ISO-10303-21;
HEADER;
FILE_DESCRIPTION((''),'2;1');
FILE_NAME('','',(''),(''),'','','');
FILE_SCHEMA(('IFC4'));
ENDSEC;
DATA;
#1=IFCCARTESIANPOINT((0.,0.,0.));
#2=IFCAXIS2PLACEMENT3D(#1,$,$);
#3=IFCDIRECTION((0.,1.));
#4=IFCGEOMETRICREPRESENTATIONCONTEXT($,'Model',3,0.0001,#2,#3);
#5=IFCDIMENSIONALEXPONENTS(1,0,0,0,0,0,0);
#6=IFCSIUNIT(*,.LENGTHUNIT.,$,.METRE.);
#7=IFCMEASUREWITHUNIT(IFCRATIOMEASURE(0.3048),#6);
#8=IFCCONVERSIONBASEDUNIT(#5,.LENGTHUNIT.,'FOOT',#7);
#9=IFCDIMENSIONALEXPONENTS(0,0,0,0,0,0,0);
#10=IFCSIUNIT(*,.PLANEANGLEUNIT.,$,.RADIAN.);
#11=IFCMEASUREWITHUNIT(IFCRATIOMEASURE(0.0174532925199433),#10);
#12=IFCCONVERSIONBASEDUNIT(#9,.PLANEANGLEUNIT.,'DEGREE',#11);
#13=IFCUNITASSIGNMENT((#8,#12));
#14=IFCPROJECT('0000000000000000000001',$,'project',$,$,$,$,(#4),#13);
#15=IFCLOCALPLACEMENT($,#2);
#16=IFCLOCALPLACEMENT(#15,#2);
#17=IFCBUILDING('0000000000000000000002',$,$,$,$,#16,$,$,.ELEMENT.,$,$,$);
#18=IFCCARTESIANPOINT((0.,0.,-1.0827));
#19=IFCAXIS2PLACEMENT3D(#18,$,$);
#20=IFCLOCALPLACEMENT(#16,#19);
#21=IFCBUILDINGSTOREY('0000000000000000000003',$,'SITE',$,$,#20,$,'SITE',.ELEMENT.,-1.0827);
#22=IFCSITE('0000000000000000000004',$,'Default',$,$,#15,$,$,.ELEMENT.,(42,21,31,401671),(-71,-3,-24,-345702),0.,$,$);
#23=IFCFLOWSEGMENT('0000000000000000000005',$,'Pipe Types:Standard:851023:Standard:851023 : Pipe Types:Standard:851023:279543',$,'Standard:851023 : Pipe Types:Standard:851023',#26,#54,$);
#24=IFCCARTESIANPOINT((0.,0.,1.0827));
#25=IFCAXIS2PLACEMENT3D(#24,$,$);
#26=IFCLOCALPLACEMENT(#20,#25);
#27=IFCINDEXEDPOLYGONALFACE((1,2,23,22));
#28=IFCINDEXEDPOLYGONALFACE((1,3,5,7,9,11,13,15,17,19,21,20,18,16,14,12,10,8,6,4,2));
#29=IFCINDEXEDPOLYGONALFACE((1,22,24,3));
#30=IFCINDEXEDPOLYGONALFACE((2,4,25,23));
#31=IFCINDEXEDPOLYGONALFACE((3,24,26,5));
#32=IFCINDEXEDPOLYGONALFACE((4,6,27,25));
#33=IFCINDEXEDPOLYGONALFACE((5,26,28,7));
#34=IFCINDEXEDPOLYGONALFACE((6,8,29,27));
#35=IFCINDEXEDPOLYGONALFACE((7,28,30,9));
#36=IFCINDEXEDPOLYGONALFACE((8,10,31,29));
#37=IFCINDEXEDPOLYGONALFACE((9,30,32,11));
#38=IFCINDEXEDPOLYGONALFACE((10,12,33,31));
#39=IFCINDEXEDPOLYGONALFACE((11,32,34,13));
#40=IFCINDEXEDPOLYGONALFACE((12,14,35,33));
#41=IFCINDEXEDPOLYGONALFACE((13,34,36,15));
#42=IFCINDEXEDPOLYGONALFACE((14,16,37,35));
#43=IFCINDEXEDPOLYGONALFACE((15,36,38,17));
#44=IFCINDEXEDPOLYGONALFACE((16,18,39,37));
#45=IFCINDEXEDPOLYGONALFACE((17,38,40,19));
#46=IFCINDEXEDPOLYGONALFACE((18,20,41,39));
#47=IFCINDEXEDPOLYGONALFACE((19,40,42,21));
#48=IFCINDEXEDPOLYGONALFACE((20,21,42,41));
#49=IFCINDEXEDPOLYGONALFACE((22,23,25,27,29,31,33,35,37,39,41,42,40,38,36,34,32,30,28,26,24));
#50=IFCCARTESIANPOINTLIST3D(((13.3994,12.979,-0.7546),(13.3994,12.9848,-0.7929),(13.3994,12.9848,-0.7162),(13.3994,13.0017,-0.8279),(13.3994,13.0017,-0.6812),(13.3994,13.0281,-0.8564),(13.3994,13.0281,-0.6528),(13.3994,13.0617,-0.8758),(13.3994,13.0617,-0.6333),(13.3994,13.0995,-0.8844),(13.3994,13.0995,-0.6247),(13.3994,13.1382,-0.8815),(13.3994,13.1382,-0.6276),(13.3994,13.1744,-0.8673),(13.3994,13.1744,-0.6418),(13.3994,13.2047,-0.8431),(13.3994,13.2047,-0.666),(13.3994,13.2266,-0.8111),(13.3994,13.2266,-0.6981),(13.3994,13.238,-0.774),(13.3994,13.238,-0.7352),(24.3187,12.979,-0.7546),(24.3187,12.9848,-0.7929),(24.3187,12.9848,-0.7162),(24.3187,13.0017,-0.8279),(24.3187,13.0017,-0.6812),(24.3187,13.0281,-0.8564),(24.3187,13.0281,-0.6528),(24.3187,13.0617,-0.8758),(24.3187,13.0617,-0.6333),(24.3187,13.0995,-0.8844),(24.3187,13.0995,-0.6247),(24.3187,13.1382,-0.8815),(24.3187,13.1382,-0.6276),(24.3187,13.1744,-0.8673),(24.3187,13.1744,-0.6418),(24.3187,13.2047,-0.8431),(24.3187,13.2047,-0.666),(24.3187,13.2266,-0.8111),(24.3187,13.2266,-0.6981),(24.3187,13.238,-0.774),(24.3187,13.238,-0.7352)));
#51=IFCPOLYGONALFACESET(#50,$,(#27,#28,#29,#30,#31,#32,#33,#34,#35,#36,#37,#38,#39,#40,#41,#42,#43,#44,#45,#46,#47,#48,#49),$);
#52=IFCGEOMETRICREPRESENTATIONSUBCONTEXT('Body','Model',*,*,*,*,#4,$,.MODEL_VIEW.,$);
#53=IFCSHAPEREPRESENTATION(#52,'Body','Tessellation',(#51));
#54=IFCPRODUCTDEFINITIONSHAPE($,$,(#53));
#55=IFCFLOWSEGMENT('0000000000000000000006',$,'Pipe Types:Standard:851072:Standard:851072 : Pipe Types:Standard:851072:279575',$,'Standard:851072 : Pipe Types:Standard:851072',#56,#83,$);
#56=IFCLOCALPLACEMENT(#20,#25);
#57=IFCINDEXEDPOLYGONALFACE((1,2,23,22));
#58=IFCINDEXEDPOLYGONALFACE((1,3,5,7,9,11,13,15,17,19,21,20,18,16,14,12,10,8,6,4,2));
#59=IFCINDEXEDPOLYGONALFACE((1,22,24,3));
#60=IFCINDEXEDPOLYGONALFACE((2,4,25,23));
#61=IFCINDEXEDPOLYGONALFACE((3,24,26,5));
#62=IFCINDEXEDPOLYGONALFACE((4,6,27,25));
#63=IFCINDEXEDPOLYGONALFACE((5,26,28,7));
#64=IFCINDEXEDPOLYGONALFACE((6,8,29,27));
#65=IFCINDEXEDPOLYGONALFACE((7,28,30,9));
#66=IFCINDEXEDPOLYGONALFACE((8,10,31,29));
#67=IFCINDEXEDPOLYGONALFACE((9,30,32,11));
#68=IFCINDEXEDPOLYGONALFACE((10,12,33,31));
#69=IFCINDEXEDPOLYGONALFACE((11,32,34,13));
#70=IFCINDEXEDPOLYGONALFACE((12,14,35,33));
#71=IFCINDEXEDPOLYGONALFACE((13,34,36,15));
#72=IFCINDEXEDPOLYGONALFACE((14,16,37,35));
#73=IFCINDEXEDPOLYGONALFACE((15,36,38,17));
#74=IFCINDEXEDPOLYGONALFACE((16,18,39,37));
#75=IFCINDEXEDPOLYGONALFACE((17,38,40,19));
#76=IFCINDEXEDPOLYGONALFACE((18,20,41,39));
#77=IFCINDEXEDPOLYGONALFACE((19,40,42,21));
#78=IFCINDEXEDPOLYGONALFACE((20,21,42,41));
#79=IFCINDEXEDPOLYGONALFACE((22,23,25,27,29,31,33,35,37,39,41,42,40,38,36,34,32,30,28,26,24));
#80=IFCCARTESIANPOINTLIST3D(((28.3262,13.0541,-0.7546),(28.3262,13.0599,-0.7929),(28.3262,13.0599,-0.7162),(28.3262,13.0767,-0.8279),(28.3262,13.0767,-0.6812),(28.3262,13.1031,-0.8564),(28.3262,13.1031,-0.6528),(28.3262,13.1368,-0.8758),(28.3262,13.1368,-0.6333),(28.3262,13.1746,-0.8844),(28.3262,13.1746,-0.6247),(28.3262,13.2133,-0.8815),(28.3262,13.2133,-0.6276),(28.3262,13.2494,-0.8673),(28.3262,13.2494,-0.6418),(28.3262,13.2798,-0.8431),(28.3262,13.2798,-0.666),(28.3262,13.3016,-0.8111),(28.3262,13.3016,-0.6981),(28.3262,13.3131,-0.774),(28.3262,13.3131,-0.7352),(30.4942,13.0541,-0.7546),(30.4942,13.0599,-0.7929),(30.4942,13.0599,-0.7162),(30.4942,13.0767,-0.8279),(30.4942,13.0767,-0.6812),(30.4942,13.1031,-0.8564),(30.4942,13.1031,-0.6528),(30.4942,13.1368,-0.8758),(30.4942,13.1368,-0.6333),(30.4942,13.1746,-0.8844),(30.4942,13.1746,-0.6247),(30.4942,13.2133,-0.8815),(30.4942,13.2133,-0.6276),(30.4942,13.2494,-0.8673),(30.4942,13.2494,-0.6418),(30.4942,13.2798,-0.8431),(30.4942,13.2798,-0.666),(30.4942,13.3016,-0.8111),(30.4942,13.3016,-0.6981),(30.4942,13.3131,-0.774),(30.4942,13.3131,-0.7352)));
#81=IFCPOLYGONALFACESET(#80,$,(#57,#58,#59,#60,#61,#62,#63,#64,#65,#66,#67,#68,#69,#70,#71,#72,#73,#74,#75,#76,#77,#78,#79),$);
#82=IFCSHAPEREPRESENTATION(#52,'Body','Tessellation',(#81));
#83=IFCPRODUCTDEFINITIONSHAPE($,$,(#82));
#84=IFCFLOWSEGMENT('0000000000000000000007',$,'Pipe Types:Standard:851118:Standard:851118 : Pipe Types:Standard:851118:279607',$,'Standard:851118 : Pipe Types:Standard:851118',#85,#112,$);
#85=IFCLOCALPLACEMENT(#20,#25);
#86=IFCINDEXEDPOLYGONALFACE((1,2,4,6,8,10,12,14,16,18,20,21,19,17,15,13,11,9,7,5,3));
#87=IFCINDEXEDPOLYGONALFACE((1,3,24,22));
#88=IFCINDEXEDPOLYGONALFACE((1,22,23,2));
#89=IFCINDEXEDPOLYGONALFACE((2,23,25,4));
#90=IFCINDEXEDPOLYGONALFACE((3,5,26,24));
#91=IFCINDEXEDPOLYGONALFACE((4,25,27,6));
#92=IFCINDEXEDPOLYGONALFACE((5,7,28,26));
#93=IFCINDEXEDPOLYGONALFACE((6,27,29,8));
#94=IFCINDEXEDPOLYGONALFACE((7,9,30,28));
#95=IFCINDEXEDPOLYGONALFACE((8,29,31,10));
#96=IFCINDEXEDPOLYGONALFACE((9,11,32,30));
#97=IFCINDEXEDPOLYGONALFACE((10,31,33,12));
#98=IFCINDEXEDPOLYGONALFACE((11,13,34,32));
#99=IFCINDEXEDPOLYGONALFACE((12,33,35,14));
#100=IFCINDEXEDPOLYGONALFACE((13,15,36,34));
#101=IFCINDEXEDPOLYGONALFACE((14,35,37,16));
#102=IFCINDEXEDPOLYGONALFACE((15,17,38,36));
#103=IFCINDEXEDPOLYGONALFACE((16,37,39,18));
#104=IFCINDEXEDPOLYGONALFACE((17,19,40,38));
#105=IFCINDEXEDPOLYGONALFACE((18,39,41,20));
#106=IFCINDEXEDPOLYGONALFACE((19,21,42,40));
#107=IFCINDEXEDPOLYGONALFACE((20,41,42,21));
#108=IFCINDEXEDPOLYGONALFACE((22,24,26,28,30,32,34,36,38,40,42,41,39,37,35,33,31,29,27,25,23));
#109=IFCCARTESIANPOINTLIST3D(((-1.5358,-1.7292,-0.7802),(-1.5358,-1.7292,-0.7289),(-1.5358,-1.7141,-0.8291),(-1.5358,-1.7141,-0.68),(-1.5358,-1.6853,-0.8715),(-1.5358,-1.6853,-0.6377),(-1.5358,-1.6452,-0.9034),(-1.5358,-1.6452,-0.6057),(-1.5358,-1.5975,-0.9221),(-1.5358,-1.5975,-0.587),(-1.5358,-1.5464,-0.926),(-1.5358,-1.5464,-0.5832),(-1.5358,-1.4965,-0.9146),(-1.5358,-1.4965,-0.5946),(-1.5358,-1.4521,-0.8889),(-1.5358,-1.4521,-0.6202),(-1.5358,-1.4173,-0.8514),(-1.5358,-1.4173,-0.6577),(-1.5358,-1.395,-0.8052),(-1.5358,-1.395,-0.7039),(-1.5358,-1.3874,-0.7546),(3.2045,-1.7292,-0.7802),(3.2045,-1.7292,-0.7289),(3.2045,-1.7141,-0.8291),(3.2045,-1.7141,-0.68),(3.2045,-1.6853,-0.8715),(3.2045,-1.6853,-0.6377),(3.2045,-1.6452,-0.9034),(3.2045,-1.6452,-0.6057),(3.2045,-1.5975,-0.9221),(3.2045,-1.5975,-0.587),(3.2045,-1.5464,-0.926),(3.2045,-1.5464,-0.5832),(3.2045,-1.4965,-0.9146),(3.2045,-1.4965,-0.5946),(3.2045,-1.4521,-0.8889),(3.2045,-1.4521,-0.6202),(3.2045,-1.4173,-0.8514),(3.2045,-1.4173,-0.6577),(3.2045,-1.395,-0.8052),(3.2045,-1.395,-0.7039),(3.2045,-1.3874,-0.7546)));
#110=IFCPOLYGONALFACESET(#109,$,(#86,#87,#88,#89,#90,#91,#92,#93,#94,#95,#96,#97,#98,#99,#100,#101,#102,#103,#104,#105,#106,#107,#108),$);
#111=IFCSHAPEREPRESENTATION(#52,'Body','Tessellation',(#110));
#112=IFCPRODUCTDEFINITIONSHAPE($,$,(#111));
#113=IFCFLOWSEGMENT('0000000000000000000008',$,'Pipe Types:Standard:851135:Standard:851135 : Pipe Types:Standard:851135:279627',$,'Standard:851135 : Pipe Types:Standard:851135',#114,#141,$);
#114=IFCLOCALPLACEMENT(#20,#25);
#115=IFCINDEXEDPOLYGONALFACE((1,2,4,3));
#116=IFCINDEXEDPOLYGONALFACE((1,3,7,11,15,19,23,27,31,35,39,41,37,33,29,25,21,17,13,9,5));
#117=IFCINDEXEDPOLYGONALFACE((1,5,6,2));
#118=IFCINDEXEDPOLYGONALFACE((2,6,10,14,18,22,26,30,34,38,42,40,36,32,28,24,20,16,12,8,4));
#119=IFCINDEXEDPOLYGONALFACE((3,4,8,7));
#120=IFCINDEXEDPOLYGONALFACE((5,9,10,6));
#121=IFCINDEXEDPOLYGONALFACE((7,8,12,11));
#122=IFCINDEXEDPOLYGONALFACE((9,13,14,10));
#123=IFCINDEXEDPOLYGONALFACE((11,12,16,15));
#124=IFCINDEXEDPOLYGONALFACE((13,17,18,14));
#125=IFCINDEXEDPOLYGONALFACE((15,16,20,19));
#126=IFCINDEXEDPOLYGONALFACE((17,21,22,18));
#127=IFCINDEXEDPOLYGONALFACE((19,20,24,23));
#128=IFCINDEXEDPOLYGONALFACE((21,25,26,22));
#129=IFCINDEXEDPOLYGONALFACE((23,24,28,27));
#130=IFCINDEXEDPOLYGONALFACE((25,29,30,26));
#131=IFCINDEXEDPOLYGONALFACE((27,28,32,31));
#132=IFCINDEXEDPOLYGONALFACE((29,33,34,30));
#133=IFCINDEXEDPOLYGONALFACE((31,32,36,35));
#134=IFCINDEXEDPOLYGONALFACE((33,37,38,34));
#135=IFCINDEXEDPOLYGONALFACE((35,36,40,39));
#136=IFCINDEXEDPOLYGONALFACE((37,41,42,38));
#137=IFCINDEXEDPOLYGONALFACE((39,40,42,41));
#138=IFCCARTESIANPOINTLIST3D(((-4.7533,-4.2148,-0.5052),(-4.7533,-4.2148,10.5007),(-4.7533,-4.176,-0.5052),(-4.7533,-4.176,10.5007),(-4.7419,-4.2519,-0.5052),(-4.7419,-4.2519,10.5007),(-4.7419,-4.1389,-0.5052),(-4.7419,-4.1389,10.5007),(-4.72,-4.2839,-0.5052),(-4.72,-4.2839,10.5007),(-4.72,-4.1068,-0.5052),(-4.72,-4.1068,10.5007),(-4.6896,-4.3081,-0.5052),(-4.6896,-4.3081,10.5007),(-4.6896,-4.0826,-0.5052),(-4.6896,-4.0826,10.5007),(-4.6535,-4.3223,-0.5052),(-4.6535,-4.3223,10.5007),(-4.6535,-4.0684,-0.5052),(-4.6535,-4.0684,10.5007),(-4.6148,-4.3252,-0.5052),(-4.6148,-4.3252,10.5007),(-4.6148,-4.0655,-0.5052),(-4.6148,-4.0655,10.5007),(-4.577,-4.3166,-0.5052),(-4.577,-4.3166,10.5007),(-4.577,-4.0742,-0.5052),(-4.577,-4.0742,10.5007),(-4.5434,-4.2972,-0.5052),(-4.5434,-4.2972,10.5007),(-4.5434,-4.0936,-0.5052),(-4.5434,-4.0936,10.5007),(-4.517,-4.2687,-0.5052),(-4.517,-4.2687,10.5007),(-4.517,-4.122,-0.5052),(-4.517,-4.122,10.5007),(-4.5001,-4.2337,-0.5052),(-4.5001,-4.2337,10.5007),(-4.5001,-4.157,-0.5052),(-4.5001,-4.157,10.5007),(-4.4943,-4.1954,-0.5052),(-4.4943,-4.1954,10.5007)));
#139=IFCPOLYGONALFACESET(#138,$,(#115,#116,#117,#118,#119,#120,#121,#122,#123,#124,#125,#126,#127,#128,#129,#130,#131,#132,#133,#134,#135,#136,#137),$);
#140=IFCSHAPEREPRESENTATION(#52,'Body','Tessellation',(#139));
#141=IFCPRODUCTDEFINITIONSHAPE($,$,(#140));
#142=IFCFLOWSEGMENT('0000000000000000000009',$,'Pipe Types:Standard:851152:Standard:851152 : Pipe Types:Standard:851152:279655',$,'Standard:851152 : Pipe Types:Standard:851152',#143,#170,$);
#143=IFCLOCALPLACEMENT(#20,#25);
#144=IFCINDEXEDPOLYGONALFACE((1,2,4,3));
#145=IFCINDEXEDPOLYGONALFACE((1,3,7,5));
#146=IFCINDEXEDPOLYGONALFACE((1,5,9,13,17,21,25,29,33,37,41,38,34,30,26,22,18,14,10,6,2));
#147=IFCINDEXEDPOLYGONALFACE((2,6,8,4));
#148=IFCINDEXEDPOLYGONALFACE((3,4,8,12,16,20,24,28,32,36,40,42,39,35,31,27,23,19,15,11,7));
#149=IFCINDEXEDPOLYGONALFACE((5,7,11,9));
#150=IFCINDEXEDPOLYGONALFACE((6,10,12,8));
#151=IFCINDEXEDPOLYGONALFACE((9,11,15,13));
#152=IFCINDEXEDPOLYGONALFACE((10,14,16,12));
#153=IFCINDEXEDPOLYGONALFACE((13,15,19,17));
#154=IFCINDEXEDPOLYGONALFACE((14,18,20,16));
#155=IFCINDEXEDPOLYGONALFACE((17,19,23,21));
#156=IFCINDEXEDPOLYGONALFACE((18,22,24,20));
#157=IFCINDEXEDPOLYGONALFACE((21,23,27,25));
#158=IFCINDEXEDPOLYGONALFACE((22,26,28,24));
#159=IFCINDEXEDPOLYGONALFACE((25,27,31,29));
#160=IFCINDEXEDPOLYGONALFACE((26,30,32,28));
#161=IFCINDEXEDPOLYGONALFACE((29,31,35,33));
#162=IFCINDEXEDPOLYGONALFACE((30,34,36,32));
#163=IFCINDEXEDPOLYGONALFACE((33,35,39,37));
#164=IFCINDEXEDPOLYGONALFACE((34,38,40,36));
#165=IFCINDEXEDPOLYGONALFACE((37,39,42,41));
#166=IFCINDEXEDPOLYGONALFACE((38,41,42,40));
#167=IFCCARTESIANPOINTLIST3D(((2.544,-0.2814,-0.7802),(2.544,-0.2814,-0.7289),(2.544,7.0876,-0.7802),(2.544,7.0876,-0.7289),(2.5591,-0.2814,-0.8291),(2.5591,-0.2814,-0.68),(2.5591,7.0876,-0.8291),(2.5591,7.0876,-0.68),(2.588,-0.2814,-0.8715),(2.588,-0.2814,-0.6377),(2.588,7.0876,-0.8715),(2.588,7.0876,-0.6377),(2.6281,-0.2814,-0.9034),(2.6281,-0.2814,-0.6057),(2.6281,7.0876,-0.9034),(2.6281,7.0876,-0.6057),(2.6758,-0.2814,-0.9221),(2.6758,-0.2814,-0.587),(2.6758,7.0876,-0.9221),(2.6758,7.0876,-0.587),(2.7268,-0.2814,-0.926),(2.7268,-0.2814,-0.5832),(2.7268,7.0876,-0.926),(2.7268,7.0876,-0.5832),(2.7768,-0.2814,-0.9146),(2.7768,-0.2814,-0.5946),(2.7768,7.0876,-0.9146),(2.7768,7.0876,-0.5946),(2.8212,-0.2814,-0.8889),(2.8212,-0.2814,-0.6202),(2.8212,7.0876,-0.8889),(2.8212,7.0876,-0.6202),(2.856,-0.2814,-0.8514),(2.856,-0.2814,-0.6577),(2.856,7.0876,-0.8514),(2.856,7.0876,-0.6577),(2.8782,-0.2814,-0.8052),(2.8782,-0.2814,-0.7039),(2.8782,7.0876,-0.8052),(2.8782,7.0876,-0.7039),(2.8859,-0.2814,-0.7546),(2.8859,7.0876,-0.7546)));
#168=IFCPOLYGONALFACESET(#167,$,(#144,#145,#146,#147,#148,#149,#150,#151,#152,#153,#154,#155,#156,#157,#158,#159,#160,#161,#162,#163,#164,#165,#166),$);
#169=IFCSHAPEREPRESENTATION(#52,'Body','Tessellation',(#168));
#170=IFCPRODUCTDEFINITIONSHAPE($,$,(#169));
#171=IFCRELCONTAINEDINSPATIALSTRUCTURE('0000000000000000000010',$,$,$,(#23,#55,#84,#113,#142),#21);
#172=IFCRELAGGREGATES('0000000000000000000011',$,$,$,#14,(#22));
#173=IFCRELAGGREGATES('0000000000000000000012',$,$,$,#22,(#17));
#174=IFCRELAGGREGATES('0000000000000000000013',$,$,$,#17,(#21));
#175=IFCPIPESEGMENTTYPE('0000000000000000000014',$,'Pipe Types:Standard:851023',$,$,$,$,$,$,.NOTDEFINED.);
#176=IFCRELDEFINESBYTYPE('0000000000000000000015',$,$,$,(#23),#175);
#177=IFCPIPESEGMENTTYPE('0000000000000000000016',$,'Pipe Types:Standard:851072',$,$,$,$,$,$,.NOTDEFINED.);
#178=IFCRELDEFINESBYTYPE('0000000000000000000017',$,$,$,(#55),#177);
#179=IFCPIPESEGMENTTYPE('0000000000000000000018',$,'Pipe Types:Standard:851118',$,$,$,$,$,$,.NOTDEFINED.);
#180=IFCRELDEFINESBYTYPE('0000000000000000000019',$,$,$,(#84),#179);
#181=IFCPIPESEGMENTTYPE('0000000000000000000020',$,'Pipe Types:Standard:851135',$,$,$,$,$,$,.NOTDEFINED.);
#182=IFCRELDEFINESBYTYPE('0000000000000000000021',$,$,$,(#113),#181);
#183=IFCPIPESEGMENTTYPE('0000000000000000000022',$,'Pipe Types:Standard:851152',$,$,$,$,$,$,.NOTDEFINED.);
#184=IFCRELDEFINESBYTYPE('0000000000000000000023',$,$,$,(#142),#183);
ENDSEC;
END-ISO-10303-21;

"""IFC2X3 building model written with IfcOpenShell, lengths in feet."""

from ifc_helpers import new_model, entity, si_unit, converted_unit, direction, frame, frame_2d, origin, origin_2d_with_axis, place, context, subcontext, project, spatial, circle, extrude, source, transform, mapped, type_object, type_shapes, element, save


model = new_model("IFC2X3")

# Units and contexts
model_context = context("Model", 3, precision=0.0001, world=origin(), true_north=direction((0.0, 1.0)))
body_context = subcontext(model_context, "Body", "Model", "MODEL_VIEW")
ifc_project = project(units=[converted_unit("LENGTHUNIT", "FOOT", entity("IfcRatioMeasure", 0.3048), si_unit("LENGTHUNIT", "METRE"), dimensions=[1, 0, 0, 0, 0, 0, 0]), converted_unit("PLANEANGLEUNIT", "DEGREE", entity("IfcRatioMeasure", 0.0174532925199433), si_unit("PLANEANGLEUNIT", "RADIAN"), dimensions=[0, 0, 0, 0, 0, 0, 0])], contexts=[model_context])

# Site, building, storey
site_placement = place(None, origin())
site = spatial("IfcSite", under=ifc_project, at=site_placement, Name="Default", CompositionType="ELEMENT", RefLatitude=(42, 21, 31, 401671), RefLongitude=(-71, -3, -24, -345702), RefElevation=0.0)
building_placement = place(site_placement, origin())
building = spatial("IfcBuilding", under=site, at=building_placement, CompositionType="ELEMENT")
storey_placement = place(building_placement, frame((0.0, 0.0, -1.0827)))
storey = spatial("IfcBuildingStorey", under=building, at=storey_placement, Name="SITE", LongName="SITE", CompositionType="ELEMENT", Elevation=-1.0827)

# Flow segments
pipe_segment_type_1 = type_object("IfcPipeSegmentType", Name="Pipe Types:Standard:851023", PredefinedType="NOTDEFINED")
shared_shape_1 = source(origin(), body_context, "Body", "SweptSolid", [
    extrude(circle(Radius=0.1302, at=frame_2d((0.0, 0.0), x_axis=(1.0, 0.0))), frame((13.3994, 13.1092, -0.7546), z_axis=(1.0, 0.0, 0.0), x_axis=(0.0, -1.0, 0.0)), (0.0, 0.0, 1.0), 10.9193),
])
type_shapes(pipe_segment_type_1, [shared_shape_1])
flow_segment_1_placement = place(storey_placement, frame((0.0, 0.0, 1.0827)))
element("IfcFlowSegment", 1, at=flow_segment_1_placement, inside=storey, type_object=pipe_segment_type_1, Name="Pipe Types:Standard:851023:Standard:851023 : Pipe Types:Standard:851023:279543", ObjectType="Standard:851023 : Pipe Types:Standard:851023", context=body_context, shape_type="MappedRepresentation", body=[
    mapped(shared_shape_1, transform((0.0, 0.0, 0.0), scale=1.0)),
])
pipe_segment_type_2 = type_object("IfcPipeSegmentType", Name="Pipe Types:Standard:851072", PredefinedType="NOTDEFINED")
shared_shape_2 = source(origin(), body_context, "Body", "SweptSolid", [
    extrude(circle(Radius=0.1302, at=frame_2d((0.0, 0.0), x_axis=(1.0, 0.0))), frame((28.3262, 13.1843, -0.7546), z_axis=(1.0, 0.0, 0.0), x_axis=(0.0, -1.0, 0.0)), (0.0, 0.0, 1.0), 2.168),
])
type_shapes(pipe_segment_type_2, [shared_shape_2])
flow_segment_2_placement = place(storey_placement, frame((0.0, 0.0, 1.0827)))
element("IfcFlowSegment", 2, at=flow_segment_2_placement, inside=storey, type_object=pipe_segment_type_2, Name="Pipe Types:Standard:851072:Standard:851072 : Pipe Types:Standard:851072:279575", ObjectType="Standard:851072 : Pipe Types:Standard:851072", context=body_context, shape_type="MappedRepresentation", body=[
    mapped(shared_shape_2, transform((0.0, 0.0, 0.0), scale=1.0)),
])
pipe_segment_type_3 = type_object("IfcPipeSegmentType", Name="Pipe Types:Standard:851118", PredefinedType="NOTDEFINED")
shared_shape_3 = source(origin(), body_context, "Body", "SweptSolid", [
    extrude(circle(Radius=0.1719, at=frame_2d((0.0, 0.0), x_axis=(1.0, 0.0))), frame((-1.5358, -1.5593, -0.7546), z_axis=(1.0, 0.0, 0.0), x_axis=(0.0, 1.0, 0.0)), (0.0, 0.0, 1.0), 4.7403),
])
type_shapes(pipe_segment_type_3, [shared_shape_3])
flow_segment_3_placement = place(storey_placement, frame((0.0, 0.0, 1.0827)))
element("IfcFlowSegment", 3, at=flow_segment_3_placement, inside=storey, type_object=pipe_segment_type_3, Name="Pipe Types:Standard:851118:Standard:851118 : Pipe Types:Standard:851118:279607", ObjectType="Standard:851118 : Pipe Types:Standard:851118", context=body_context, shape_type="MappedRepresentation", body=[
    mapped(shared_shape_3, transform((0.0, 0.0, 0.0), scale=1.0)),
])
pipe_segment_type_4 = type_object("IfcPipeSegmentType", Name="Pipe Types:Standard:851135", PredefinedType="NOTDEFINED")
shared_shape_4 = source(origin(), body_context, "Body", "SweptSolid", [
    extrude(circle(Radius=0.1302, at=origin_2d_with_axis()), frame((-4.6245, -4.1954, -0.5052)), (0.0, 0.0, 1.0), 11.0059),
])
type_shapes(pipe_segment_type_4, [shared_shape_4])
flow_segment_4_placement = place(storey_placement, frame((0.0, 0.0, 1.0827)))
element("IfcFlowSegment", 4, at=flow_segment_4_placement, inside=storey, type_object=pipe_segment_type_4, Name="Pipe Types:Standard:851135:Standard:851135 : Pipe Types:Standard:851135:279627", ObjectType="Standard:851135 : Pipe Types:Standard:851135", context=body_context, shape_type="MappedRepresentation", body=[
    mapped(shared_shape_4, transform((0.0, 0.0, 0.0), scale=1.0)),
])
pipe_segment_type_5 = type_object("IfcPipeSegmentType", Name="Pipe Types:Standard:851152", PredefinedType="NOTDEFINED")
shared_shape_5 = source(origin(), body_context, "Body", "SweptSolid", [
    extrude(circle(Radius=0.1719, at=frame_2d((0.0, 0.0), x_axis=(1.0, 0.0))), frame((2.714, -0.2814, -0.7546), z_axis=(0.0, 1.0, 0.0), x_axis=(1.0, 0.0, 0.0)), (0.0, 0.0, 1.0), 7.369),
])
type_shapes(pipe_segment_type_5, [shared_shape_5])
flow_segment_5_placement = place(storey_placement, frame((0.0, 0.0, 1.0827)))
element("IfcFlowSegment", 5, at=flow_segment_5_placement, inside=storey, type_object=pipe_segment_type_5, Name="Pipe Types:Standard:851152:Standard:851152 : Pipe Types:Standard:851152:279655", ObjectType="Standard:851152 : Pipe Types:Standard:851152", context=body_context, shape_type="MappedRepresentation", body=[
    mapped(shared_shape_5, transform((0.0, 0.0, 0.0), scale=1.0)),
])

save(model, "model.ifc")
